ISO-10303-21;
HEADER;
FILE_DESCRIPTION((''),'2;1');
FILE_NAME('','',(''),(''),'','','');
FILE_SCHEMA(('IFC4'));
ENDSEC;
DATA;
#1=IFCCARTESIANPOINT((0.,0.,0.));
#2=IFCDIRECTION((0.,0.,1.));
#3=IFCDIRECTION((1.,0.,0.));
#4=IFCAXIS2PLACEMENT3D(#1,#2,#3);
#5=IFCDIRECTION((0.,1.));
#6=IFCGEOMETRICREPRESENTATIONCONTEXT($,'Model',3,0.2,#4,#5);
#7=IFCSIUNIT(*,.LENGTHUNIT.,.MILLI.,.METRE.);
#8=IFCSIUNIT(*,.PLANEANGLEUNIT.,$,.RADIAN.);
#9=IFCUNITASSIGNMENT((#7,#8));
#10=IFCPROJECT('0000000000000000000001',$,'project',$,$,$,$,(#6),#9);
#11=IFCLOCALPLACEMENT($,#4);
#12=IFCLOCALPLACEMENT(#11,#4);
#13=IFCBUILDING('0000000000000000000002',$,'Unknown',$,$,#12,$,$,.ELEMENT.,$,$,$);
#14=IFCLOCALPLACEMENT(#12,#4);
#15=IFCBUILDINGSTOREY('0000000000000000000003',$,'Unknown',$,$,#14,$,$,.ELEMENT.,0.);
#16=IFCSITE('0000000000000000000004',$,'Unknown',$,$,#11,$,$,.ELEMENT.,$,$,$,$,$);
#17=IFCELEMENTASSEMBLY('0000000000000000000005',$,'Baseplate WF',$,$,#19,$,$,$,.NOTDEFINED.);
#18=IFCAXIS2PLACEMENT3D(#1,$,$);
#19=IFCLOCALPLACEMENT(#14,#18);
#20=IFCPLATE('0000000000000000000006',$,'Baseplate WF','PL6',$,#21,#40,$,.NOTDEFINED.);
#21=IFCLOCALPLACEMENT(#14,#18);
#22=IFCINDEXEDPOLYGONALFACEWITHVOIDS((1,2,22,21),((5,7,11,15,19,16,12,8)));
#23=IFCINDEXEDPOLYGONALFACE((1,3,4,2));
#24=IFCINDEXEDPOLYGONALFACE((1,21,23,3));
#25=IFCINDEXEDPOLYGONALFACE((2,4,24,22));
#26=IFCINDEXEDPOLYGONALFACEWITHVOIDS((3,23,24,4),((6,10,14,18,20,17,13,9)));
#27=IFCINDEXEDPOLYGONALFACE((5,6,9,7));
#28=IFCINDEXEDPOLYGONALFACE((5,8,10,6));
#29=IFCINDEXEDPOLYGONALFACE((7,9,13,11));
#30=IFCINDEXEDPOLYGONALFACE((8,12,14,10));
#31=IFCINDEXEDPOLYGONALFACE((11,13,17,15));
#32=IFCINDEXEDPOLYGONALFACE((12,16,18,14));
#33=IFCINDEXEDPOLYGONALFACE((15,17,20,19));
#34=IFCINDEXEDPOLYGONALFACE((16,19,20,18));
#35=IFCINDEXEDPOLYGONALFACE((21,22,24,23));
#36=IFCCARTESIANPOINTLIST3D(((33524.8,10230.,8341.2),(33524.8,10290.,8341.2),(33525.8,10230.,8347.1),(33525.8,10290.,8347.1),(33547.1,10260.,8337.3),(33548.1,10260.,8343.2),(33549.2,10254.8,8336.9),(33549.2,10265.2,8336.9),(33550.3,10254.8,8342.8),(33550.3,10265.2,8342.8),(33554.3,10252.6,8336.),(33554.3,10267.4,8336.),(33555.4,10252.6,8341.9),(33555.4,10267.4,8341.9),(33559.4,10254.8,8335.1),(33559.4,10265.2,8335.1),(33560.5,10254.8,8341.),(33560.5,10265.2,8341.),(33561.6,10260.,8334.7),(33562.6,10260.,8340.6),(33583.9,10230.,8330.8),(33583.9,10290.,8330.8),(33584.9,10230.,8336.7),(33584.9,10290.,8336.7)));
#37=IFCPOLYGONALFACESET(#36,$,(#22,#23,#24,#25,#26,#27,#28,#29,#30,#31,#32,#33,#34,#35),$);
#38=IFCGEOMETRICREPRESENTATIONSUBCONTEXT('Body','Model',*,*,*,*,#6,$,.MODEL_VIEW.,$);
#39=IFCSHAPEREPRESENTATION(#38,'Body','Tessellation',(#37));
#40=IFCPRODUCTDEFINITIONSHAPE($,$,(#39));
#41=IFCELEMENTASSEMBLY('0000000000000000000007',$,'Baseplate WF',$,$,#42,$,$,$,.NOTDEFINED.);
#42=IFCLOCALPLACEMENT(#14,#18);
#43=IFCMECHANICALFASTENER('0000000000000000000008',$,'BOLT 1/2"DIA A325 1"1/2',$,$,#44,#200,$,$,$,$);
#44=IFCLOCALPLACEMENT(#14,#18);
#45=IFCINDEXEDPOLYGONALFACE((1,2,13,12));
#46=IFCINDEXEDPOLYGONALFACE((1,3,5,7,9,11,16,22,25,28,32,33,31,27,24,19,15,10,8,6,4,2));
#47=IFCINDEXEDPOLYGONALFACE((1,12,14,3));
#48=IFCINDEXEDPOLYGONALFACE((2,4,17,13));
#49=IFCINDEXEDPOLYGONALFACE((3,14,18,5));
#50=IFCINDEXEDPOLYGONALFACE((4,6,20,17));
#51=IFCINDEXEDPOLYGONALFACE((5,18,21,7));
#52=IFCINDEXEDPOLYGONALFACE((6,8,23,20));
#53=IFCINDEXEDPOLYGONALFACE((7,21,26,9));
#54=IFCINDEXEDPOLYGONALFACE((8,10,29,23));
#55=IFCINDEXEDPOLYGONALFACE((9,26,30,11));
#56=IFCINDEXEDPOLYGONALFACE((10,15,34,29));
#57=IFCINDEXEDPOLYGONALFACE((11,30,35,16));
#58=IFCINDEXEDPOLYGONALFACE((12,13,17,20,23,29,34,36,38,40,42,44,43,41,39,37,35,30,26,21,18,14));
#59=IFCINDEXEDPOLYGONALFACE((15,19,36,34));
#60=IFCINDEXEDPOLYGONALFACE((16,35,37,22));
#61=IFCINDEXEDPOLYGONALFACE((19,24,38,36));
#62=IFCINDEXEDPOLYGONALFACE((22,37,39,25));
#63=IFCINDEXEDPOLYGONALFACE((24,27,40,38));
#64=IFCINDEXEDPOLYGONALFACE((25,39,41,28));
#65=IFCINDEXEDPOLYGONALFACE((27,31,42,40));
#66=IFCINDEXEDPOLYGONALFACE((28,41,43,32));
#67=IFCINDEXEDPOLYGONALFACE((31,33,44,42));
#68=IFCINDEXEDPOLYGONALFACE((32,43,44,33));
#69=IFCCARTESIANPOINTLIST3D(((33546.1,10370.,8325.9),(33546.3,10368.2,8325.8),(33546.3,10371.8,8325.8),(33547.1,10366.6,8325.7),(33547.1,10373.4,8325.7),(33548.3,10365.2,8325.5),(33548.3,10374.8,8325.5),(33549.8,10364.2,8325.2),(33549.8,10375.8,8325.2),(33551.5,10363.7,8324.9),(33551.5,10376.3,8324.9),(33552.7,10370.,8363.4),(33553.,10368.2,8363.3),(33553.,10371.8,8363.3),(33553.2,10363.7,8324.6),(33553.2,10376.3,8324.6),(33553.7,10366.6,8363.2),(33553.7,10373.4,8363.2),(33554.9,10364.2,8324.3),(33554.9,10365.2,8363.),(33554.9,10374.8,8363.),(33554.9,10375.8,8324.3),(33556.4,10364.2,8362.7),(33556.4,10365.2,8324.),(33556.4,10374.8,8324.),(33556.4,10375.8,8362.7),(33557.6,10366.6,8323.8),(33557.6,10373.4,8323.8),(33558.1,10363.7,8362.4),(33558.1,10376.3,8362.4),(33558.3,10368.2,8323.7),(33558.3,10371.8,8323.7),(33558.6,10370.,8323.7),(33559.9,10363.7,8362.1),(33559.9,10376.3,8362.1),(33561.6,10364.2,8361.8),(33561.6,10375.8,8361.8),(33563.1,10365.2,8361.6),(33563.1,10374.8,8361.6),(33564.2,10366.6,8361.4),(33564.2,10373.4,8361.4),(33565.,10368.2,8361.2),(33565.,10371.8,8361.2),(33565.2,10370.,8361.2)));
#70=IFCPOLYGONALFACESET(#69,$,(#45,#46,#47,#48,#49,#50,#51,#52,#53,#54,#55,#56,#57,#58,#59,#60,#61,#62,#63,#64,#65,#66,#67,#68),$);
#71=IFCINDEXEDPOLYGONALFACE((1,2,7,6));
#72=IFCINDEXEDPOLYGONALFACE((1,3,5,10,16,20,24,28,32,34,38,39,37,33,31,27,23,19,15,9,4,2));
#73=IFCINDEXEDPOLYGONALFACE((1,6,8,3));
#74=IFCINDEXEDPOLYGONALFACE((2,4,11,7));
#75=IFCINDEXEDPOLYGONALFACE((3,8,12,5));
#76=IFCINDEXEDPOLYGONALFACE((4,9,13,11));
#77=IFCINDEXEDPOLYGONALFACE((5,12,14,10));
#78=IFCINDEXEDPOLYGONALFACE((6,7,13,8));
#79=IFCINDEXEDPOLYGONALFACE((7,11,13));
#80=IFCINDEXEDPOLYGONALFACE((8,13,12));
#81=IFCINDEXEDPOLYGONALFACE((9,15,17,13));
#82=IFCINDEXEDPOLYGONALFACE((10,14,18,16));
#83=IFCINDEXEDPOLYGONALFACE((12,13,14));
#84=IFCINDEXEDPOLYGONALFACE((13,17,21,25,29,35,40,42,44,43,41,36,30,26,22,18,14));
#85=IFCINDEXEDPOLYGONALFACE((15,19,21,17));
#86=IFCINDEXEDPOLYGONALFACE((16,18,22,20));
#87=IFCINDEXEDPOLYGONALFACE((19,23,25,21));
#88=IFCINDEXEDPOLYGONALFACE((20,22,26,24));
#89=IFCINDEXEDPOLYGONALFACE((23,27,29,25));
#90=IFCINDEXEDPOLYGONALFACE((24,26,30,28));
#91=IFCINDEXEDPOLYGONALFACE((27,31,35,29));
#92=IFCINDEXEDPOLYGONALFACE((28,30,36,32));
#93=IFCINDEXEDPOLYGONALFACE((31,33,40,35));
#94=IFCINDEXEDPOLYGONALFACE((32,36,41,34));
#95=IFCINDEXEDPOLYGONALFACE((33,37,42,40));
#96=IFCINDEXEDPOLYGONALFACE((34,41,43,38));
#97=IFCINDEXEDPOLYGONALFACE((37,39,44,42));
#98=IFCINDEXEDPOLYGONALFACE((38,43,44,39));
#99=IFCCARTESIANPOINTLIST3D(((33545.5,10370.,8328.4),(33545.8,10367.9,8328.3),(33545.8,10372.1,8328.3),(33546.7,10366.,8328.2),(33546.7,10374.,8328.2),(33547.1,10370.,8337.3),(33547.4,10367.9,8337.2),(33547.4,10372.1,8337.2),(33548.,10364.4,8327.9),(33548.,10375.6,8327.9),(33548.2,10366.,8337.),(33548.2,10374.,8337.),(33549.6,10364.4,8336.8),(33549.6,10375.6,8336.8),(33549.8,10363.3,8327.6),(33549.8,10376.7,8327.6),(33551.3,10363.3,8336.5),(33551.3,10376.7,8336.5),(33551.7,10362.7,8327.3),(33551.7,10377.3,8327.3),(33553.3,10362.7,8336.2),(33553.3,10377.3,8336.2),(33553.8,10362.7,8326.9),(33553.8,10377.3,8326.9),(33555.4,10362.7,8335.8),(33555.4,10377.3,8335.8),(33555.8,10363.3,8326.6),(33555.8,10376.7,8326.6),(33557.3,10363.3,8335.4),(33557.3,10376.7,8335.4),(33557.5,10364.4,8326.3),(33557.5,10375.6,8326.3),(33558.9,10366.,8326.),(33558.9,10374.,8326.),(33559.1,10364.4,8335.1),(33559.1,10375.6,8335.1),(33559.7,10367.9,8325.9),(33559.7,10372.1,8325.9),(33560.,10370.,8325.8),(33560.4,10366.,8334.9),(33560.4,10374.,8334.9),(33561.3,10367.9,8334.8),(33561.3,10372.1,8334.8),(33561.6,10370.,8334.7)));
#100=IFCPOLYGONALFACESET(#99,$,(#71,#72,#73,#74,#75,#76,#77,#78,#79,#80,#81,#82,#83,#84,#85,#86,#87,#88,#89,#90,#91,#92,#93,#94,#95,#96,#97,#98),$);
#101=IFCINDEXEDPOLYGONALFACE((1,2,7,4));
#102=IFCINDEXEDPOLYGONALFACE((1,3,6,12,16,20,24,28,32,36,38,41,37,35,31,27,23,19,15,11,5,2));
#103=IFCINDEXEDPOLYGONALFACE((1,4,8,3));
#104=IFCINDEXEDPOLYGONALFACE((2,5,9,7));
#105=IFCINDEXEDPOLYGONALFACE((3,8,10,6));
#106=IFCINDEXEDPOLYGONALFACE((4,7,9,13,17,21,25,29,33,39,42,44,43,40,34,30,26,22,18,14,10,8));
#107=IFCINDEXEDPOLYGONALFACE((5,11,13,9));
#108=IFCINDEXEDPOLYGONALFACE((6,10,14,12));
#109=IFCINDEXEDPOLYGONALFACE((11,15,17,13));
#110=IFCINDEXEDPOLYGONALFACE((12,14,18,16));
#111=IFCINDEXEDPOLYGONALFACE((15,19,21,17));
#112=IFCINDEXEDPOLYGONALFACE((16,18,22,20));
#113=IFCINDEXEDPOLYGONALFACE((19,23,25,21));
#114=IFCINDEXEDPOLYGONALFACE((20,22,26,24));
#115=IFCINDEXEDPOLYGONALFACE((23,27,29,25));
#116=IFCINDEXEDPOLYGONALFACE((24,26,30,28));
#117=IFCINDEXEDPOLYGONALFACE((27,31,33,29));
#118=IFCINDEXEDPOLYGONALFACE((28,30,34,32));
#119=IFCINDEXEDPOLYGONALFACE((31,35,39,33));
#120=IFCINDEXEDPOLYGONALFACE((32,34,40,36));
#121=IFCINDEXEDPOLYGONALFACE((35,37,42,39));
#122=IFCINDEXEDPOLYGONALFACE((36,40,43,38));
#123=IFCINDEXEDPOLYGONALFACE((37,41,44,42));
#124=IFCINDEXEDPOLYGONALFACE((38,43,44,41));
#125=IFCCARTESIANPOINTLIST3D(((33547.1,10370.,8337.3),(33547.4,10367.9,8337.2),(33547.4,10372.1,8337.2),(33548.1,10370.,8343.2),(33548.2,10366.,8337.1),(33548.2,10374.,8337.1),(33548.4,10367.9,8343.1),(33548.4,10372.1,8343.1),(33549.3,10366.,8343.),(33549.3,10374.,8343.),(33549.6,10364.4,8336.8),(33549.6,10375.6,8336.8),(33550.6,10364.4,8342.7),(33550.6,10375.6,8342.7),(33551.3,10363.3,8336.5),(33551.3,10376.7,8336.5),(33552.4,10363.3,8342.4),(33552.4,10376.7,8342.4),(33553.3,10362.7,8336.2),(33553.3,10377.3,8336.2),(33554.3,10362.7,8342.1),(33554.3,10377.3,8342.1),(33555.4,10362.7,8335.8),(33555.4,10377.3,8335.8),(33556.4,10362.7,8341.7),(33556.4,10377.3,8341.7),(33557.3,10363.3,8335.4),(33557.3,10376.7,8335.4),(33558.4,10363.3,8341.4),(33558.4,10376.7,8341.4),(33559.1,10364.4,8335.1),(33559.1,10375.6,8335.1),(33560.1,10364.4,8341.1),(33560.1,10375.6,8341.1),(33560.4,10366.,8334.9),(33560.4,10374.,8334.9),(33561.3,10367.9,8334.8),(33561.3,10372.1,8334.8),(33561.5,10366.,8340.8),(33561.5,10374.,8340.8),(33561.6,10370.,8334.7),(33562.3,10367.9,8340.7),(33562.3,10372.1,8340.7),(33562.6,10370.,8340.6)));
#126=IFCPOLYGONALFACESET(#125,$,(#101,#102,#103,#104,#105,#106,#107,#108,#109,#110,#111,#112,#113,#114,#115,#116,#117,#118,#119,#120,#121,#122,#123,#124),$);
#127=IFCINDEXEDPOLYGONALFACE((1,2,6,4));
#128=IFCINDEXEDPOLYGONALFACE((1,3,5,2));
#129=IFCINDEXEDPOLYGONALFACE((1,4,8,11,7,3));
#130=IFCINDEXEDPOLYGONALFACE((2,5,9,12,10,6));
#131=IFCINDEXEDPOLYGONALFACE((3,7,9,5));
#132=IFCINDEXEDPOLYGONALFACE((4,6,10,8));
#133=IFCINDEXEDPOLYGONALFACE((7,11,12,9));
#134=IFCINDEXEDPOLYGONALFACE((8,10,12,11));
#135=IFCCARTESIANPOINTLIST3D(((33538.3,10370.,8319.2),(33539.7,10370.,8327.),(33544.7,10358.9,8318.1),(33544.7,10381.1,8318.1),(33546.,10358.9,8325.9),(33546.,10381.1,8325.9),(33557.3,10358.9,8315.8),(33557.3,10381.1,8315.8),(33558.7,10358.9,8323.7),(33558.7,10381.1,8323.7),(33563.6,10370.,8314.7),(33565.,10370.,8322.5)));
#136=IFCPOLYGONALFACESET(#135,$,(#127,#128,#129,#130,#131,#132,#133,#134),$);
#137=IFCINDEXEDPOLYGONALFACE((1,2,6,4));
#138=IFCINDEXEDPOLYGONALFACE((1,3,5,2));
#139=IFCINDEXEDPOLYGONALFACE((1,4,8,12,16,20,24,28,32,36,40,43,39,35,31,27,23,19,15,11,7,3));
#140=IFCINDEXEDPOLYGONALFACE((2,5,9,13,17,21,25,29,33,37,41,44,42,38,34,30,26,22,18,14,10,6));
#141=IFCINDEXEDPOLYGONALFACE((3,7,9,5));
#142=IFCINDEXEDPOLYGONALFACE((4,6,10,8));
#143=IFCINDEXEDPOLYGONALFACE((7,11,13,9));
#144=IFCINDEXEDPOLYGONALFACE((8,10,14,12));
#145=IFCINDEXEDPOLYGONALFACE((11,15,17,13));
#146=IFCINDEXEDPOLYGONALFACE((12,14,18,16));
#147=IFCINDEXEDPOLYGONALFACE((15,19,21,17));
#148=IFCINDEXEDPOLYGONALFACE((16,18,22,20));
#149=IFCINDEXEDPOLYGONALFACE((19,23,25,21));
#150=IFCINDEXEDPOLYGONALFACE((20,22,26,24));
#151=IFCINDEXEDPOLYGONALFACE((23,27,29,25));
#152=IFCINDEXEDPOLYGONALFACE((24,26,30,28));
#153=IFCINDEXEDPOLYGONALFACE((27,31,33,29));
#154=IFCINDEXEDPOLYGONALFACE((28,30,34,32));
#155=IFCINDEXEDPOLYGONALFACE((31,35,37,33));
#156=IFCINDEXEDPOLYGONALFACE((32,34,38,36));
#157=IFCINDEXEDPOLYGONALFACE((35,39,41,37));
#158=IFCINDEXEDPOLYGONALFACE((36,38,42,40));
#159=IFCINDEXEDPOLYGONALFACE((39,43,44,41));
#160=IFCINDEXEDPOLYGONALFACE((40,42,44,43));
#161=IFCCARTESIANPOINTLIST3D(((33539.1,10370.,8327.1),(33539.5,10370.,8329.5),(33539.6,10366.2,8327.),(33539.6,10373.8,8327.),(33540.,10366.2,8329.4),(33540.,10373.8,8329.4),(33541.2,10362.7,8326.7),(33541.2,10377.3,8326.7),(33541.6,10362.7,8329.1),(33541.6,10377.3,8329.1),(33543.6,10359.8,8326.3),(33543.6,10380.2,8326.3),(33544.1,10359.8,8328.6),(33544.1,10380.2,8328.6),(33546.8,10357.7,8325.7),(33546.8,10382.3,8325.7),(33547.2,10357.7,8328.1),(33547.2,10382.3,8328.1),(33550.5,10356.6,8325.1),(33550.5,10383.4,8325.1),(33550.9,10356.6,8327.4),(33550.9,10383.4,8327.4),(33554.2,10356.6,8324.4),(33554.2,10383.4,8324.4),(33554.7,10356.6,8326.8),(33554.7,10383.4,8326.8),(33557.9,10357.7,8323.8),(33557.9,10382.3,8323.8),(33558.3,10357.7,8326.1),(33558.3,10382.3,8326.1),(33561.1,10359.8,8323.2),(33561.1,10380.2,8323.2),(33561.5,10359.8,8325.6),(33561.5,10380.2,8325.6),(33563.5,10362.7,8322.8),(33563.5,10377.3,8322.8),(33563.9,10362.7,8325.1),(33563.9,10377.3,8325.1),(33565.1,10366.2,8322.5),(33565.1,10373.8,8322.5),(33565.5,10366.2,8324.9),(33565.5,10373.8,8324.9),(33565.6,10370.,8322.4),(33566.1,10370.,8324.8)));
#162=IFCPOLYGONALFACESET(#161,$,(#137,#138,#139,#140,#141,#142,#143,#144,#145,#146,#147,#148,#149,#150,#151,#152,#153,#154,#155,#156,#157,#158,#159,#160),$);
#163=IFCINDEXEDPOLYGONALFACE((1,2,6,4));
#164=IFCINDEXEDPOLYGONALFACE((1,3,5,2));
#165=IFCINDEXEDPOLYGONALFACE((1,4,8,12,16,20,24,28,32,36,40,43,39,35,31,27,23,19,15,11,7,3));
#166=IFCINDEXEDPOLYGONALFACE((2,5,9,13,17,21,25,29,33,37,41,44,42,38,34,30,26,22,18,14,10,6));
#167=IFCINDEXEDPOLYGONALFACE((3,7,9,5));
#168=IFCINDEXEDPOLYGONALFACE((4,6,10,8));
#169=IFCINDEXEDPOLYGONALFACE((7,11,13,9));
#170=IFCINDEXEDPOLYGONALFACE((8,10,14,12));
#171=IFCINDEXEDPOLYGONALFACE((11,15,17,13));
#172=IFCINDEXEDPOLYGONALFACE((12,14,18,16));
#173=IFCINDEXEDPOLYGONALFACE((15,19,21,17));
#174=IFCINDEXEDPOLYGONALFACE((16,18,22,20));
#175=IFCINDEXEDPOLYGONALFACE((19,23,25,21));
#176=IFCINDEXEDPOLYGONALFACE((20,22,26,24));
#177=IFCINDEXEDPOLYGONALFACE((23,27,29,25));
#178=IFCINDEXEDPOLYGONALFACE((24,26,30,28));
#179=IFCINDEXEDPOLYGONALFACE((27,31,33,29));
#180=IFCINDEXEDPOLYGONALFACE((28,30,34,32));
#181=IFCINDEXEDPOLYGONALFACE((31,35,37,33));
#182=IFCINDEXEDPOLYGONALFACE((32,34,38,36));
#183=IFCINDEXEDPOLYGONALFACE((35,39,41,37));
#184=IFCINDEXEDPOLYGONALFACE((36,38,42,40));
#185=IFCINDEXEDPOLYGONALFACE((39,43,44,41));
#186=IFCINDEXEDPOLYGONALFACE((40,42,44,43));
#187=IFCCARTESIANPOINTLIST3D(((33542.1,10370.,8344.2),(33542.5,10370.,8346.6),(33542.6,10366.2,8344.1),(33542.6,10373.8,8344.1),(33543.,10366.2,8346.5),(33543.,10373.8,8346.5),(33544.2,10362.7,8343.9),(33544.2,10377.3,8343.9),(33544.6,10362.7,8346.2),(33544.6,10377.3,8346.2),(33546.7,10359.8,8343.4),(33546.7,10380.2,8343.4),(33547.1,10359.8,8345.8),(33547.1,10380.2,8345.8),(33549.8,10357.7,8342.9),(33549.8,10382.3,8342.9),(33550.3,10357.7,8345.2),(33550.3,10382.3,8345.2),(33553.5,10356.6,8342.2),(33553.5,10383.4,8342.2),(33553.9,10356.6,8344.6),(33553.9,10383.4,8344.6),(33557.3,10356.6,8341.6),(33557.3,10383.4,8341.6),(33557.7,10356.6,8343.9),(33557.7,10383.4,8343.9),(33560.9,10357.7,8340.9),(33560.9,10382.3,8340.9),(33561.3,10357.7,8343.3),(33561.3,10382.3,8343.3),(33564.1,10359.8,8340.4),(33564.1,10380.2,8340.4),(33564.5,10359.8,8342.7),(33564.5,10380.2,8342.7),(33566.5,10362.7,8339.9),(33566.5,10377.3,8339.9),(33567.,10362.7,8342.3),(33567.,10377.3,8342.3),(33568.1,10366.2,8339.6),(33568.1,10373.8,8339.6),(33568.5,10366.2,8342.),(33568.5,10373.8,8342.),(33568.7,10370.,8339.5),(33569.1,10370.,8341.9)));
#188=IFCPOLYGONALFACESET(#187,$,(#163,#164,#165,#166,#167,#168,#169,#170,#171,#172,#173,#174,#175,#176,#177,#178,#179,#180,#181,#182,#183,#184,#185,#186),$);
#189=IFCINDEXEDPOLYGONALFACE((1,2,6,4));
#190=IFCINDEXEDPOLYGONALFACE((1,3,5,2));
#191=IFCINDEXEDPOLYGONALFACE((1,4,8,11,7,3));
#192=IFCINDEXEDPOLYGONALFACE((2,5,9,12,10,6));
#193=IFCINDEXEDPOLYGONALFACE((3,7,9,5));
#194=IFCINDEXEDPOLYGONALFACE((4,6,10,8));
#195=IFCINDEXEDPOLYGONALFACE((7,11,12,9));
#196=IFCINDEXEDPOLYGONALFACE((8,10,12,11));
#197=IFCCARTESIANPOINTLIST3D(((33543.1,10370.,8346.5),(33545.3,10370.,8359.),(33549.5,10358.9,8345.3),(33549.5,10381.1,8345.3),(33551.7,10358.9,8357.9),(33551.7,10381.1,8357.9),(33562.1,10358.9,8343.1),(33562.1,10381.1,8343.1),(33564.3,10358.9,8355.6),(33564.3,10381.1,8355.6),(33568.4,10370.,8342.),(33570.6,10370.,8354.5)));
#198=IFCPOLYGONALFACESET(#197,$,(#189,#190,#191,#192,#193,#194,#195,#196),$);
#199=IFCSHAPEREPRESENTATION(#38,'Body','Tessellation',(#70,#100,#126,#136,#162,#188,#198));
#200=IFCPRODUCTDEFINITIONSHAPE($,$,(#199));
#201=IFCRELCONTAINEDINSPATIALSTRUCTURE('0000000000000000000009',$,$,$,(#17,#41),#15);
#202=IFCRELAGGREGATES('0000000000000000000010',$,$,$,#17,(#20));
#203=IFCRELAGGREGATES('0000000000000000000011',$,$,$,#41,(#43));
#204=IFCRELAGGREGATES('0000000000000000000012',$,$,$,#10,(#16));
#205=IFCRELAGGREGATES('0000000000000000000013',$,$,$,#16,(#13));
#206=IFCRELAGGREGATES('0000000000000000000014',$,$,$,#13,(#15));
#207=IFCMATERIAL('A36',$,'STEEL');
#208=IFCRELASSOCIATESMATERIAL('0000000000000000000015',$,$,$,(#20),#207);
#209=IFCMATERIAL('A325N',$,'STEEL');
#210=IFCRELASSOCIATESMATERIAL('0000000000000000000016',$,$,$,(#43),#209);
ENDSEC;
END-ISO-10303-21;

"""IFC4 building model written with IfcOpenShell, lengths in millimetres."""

from ifc_helpers import new_model, si_unit, direction, frame, origin_with_axes, place, context, subcontext, project, spatial, line, arc, indexed_curve, outline, extrude, source, transform, mapped, material, element, aggregate, save


model = new_model("IFC4")

# Units and contexts
model_context = context("Model", 3, precision=0.2, world=origin_with_axes(), true_north=direction((0.0, 1.0)))
body_context = subcontext(model_context, "Body", "Model", "MODEL_VIEW")
ifc_project = project(units=[si_unit("LENGTHUNIT", "METRE", prefix="MILLI"), si_unit("PLANEANGLEUNIT", "RADIAN")], contexts=[model_context])

# Site, building, storey
site_placement = place(None, origin_with_axes())
site = spatial("IfcSite", under=ifc_project, at=site_placement, Name="Unknown", CompositionType="ELEMENT")
building_placement = place(site_placement, origin_with_axes())
building = spatial("IfcBuilding", under=site, at=building_placement, Name="Unknown", CompositionType="ELEMENT")
storey_placement = place(building_placement, origin_with_axes())
storey = spatial("IfcBuildingStorey", under=building, at=storey_placement, Name="Unknown", CompositionType="ELEMENT", Elevation=0.0)

# Element assembly, plate, voiding features
assembly_1_placement = place(storey_placement, frame((33584.4, 10290.0, 8333.7), z_axis=(-0.173648, 0.0, -0.984808), x_axis=(0.0, -1.0, 0.0)))
assembly_1 = element("IfcElementAssembly", 1, at=assembly_1_placement, inside=storey, Name="Baseplate WF", PredefinedType="NOTDEFINED")
ifc_material_1 = material(Name="A36", Category="STEEL")
plate_placement = place(assembly_1_placement, origin_with_axes())
plate = element("IfcPlate", 2, at=plate_placement, material=ifc_material_1, Name="Baseplate WF", Description="PL6", PredefinedType="NOTDEFINED", context=body_context, shape_type="SolidModel", body=[
    extrude(outline(indexed_curve([(0.0, 0.0), (60.0, 0.0), (60.0, 60.0), (0.0, 60.0)], segments=[line(1, 2, 3, 4, 1)])), frame((0.0, 0.0, 3.0), z_axis=(0.0, 0.0, 1.0), x_axis=(1.0, 0.0, 0.0)), (0.0, 0.0, -1.0), 6.0),
])
voiding_feature_1_placement = place(plate_placement, frame((30.0, 30.0, -3.5), z_axis=(-1.0, 0.0, 0.0), x_axis=(0.0, 0.0, 1.0)))
element("IfcVoidingFeature", 3, at=voiding_feature_1_placement, cuts=plate, Name="BEAM", PredefinedType="HOLE", context=body_context, shape_type="SolidModel", body=[
    extrude(outline(indexed_curve([(7.4, 0.0), (5.2, 5.2), (0.0, 7.4), (-5.2, 5.2), (-7.4, 0.0), (-5.2, -5.2), (0.0, -7.4), (5.2, -5.2)], segments=[line(1, 2, 3, 4, 5, 6, 7, 8, 1)])), frame((0.0, 0.0, 0.0), z_axis=(-1.0, 0.0, 0.0), x_axis=(0.0, 0.0, 1.0)), (0.0, 0.0, -1.0), 7.0),
])
voiding_feature_2_placement = place(plate_placement, frame((-80.0, 30.0, -3.5), z_axis=(-1.0, 0.0, 0.0), x_axis=(0.0, 0.0, 1.0)))
element("IfcVoidingFeature", 4, at=voiding_feature_2_placement, cuts=plate, Name="BEAM", PredefinedType="HOLE", context=body_context, shape_type="SolidModel", body=[
    extrude(outline(indexed_curve([(7.4, 0.0), (5.2, 5.2), (0.0, 7.4), (-5.2, 5.2), (-7.4, 0.0), (-5.2, -5.2), (0.0, -7.4), (5.2, -5.2)], segments=[line(1, 2, 3, 4, 5, 6, 7, 8, 1)])), frame((0.0, 0.0, 0.0), z_axis=(-1.0, 0.0, 0.0), x_axis=(0.0, 0.0, 1.0)), (0.0, 0.0, -1.0), 7.0),
])
aggregate(assembly_1, [plate])

# Element assembly, mechanical fastener
assembly_2_placement = place(storey_placement, frame((33584.4, 10400.0, 8333.7), z_axis=(-0.173648, 0.0, -0.984808), x_axis=(0.0, -1.0, 0.0)))
assembly_2 = element("IfcElementAssembly", 5, at=assembly_2_placement, inside=storey, Name="Baseplate WF", PredefinedType="NOTDEFINED")
ifc_material_2 = material(Name="A325N", Category="STEEL")
shared_shape = source(origin_with_axes(), body_context, "Body", "SweptSolid", [
    extrude(outline(indexed_curve([(6.3, 0.0), (0.0, 6.3), (-6.3, 0.0), (0.0, -6.3)], segments=[arc(1, 2, 3), arc(3, 4, 1)])), frame((0.0, 0.0, 17.4), z_axis=(0.0, 0.0, -1.0), x_axis=(0.0, 1.0, 0.0)), (0.0, 0.0, 1.0), 38.1),
    extrude(outline(indexed_curve([(7.3, 0.0), (0.0, 7.3), (-7.3, 0.0), (0.0, -7.3)], segments=[arc(1, 2, 3), arc(3, 4, 1)])), frame((0.0, 0.0, 15.0), z_axis=(0.0, 0.0, -1.0), x_axis=(0.0, 1.0, 0.0)), (0.0, 0.0, 1.0), 9.0),
    extrude(outline(indexed_curve([(7.3, 0.0), (0.0, 7.3), (-7.3, 0.0), (0.0, -7.3)], segments=[arc(1, 2, 3), arc(3, 4, 1)])), frame((0.0, 0.0, 6.0), z_axis=(0.0, 0.0, -1.0), x_axis=(0.0, 1.0, 0.0)), (0.0, 0.0, 1.0), 6.0),
    extrude(outline(indexed_curve([(12.8, 0.0), (6.4, 11.1), (-6.4, 11.1), (-12.8, 0.0), (-6.4, -11.1), (6.4, -11.1)], segments=[line(1, 2, 3, 4, 5, 6, 1)])), frame((0.0, 0.0, 25.3), z_axis=(0.0, 0.0, -1.0), x_axis=(0.0, 1.0, 0.0)), (0.0, 0.0, 1.0), 7.9),
    extrude(outline(indexed_curve([(13.5, 0.0), (0.0, 13.5), (-13.5, 0.0), (0.0, -13.5)], segments=[arc(1, 2, 3), arc(3, 4, 1)])), frame((0.0, 0.0, 17.4), z_axis=(0.0, 0.0, -1.0), x_axis=(0.0, 1.0, 0.0)), (0.0, 0.0, 1.0), 2.4),
    extrude(outline(indexed_curve([(13.5, 0.0), (0.0, 13.5), (-13.5, 0.0), (0.0, -13.5)], segments=[arc(1, 2, 3), arc(3, 4, 1)])), frame((0.0, 0.0, 0.0), z_axis=(0.0, 0.0, -1.0), x_axis=(0.0, 1.0, 0.0)), (0.0, 0.0, 1.0), 2.4),
    extrude(outline(indexed_curve([(12.8, 0.0), (6.4, 11.1), (-6.4, 11.1), (-12.8, 0.0), (-6.4, -11.1), (6.4, -11.1)], segments=[line(1, 2, 3, 4, 5, 6, 1)])), frame((0.0, 0.0, -2.4), z_axis=(0.0, 0.0, -1.0), x_axis=(0.0, 1.0, 0.0)), (0.0, 0.0, 1.0), 12.7),
])
mechanical_fastener_placement = place(assembly_2_placement, frame((30.0, 30.0, -3.0), z_axis=(0.0, 0.0, 1.0), x_axis=(1.0, 0.0, 0.0)))
mechanical_fastener = element("IfcMechanicalFastener", 6, at=mechanical_fastener_placement, material=ifc_material_2, Name="BOLT 1/2\"DIA A325 1\"1/2", context=body_context, shape_type="MappedRepresentation", body=[
    mapped(shared_shape, transform((0.0, 0.0, 0.0))),
])
aggregate(assembly_2, [mechanical_fastener])

save(model, "model.ifc")
